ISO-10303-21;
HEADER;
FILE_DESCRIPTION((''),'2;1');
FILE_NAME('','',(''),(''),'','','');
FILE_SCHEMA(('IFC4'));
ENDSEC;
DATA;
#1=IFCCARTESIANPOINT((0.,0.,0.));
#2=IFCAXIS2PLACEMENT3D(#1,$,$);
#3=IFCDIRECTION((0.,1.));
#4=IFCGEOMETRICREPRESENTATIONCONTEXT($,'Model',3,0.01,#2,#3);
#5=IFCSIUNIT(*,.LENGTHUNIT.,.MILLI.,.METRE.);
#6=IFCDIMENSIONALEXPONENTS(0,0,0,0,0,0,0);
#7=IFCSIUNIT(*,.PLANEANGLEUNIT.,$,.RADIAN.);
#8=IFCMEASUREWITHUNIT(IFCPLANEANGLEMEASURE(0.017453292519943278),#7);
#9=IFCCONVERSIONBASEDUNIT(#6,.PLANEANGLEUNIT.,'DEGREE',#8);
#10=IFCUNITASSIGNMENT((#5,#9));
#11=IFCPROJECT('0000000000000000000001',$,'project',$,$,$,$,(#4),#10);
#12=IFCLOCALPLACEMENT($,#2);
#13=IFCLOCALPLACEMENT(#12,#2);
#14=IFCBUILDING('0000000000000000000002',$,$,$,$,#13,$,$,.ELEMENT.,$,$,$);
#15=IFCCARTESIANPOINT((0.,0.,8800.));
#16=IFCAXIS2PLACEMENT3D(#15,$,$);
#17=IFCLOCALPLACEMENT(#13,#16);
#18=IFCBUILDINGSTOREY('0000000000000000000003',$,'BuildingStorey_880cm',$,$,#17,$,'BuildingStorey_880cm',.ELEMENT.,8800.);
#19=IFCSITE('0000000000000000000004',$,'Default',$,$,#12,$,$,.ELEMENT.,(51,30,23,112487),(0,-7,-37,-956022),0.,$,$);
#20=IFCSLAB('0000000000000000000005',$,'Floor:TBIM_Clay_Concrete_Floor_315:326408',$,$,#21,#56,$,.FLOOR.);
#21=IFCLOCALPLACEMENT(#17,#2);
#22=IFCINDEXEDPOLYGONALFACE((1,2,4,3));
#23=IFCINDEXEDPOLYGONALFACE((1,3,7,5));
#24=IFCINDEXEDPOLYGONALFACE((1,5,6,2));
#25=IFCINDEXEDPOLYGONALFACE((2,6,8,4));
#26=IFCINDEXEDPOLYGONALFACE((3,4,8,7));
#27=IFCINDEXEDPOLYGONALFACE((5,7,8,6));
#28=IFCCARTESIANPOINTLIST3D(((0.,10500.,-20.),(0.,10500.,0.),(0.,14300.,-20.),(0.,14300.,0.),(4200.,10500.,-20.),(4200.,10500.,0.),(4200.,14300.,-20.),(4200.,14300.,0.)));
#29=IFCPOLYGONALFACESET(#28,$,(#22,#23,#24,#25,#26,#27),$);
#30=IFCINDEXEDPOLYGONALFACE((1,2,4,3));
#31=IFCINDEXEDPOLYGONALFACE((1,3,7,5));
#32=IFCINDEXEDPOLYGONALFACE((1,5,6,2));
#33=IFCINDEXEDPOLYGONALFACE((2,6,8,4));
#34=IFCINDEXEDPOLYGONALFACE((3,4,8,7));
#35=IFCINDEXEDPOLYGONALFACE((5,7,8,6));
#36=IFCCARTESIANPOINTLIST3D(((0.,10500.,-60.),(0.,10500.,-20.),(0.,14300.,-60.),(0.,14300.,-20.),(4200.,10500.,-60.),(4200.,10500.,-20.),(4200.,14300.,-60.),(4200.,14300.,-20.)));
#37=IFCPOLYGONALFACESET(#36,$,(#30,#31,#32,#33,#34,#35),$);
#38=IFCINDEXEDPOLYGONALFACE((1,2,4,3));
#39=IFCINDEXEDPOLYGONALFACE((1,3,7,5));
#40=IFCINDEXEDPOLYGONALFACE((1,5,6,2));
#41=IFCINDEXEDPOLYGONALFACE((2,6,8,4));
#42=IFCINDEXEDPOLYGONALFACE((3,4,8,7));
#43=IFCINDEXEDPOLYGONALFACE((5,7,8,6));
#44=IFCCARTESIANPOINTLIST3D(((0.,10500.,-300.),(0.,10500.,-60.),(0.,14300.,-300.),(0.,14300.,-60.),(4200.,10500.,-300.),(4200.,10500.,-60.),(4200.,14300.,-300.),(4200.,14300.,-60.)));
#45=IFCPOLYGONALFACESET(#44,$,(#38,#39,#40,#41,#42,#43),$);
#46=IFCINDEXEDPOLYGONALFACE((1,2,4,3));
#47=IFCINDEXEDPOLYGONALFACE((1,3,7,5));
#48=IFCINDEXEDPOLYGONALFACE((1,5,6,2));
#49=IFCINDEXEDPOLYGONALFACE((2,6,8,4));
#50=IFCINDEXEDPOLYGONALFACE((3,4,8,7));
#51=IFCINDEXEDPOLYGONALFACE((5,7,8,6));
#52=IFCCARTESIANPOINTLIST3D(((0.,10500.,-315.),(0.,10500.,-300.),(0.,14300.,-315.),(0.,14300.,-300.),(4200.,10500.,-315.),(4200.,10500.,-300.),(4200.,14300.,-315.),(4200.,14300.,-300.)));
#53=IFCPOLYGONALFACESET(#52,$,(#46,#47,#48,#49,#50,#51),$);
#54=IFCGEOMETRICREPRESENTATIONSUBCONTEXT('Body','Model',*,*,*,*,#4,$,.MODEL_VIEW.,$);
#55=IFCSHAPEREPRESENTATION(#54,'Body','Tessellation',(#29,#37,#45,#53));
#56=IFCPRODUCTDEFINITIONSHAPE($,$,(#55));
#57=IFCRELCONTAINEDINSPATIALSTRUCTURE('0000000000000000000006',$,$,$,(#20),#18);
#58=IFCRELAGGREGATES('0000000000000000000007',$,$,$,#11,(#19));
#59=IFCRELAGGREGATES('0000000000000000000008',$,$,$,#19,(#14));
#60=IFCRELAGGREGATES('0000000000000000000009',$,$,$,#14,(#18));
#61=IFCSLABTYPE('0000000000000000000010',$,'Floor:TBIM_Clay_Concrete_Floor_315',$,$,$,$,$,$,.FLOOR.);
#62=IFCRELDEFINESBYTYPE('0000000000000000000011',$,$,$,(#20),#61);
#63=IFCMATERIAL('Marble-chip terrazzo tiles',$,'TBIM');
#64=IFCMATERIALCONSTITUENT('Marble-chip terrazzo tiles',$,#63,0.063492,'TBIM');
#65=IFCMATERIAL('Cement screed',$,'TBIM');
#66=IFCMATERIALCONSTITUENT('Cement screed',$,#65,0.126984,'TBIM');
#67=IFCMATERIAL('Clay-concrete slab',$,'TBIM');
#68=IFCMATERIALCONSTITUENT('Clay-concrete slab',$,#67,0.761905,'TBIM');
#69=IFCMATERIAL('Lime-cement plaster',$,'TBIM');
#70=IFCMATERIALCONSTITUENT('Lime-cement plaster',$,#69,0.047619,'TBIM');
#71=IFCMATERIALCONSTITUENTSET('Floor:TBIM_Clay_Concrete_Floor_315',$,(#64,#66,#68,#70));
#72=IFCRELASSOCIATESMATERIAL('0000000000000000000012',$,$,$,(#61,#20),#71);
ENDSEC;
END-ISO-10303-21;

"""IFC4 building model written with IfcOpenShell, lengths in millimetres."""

from ifc_helpers import new_model, entity, si_unit, converted_unit, direction, frame, origin, place, context, subcontext, project, spatial, indexed_curve, outline, extrude, material, constituent, constituent_set, type_object, element, save


model = new_model("IFC4")

# Units and contexts
model_context = context("Model", 3, precision=0.01, world=origin(), true_north=direction((0.0, 1.0)))
body_context = subcontext(model_context, "Body", "Model", "MODEL_VIEW")
ifc_project = project(units=[si_unit("LENGTHUNIT", "METRE", prefix="MILLI"), converted_unit("PLANEANGLEUNIT", "DEGREE", entity("IfcPlaneAngleMeasure", 0.017453292519943278), si_unit("PLANEANGLEUNIT", "RADIAN"), dimensions=[0, 0, 0, 0, 0, 0, 0])], contexts=[model_context])

# Site, building, storey
site_placement = place(None, origin())
site = spatial("IfcSite", under=ifc_project, at=site_placement, Name="Default", CompositionType="ELEMENT", RefLatitude=(51, 30, 23, 112487), RefLongitude=(0, -7, -37, -956022), RefElevation=0.0)
building_placement = place(site_placement, origin())
building = spatial("IfcBuilding", under=site, at=building_placement, CompositionType="ELEMENT")
storey_placement = place(building_placement, frame((0.0, 0.0, 8800.0)))
storey = spatial("IfcBuildingStorey", under=building, at=storey_placement, Name="BuildingStorey_880cm", LongName="BuildingStorey_880cm", CompositionType="ELEMENT", Elevation=8800.0)

# Slab
ifc_material_1 = material(Name="Marble-chip terrazzo tiles", Category="TBIM")
ifc_constituent_1 = constituent(ifc_material_1, Name="Marble-chip terrazzo tiles", Category="TBIM", fraction=0.063492)
ifc_material_2 = material(Name="Cement screed", Category="TBIM")
ifc_constituent_2 = constituent(ifc_material_2, Name="Cement screed", Category="TBIM", fraction=0.126984)
ifc_material_3 = material(Name="Clay-concrete slab", Category="TBIM")
ifc_constituent_3 = constituent(ifc_material_3, Name="Clay-concrete slab", Category="TBIM", fraction=0.761905)
ifc_material_4 = material(Name="Lime-cement plaster", Category="TBIM")
ifc_constituent_4 = constituent(ifc_material_4, Name="Lime-cement plaster", Category="TBIM", fraction=0.047619)
ifc_constituent_set_1 = constituent_set(constituents=[ifc_constituent_1, ifc_constituent_2, ifc_constituent_3, ifc_constituent_4], Name="Floor:TBIM_Clay_Concrete_Floor_315")
slab_type = type_object("IfcSlabType", Name="Floor:TBIM_Clay_Concrete_Floor_315", PredefinedType="FLOOR", material=ifc_constituent_set_1)
slab_1_placement = place(storey_placement, origin())
element("IfcSlab", 1, at=slab_1_placement, inside=storey, type_object=slab_type, material=ifc_constituent_set_1, Name="Floor:TBIM_Clay_Concrete_Floor_315:326408", PredefinedType="FLOOR", context=body_context, shape_type="SweptSolid", body=[
    extrude(outline(indexed_curve([(-2100.0, -1900.0), (2100.0, -1900.0), (2100.0, 1900.0), (-2100.0, 1900.0), (-2100.0, -1900.0)], self_intersect=False)), frame((2100.0, 12400.0, -20.0), z_axis=(0.0, 0.0, 1.0), x_axis=(-1.0, 0.0, 0.0)), (0.0, 0.0, 1.0), 20.0),
    extrude(outline(indexed_curve([(-2100.0, -1900.0), (2100.0, -1900.0), (2100.0, 1900.0), (-2100.0, 1900.0), (-2100.0, -1900.0)], self_intersect=False)), frame((2100.0, 12400.0, -60.0), z_axis=(0.0, 0.0, 1.0), x_axis=(-1.0, 0.0, 0.0)), (0.0, 0.0, 1.0), 40.0),
    extrude(outline(indexed_curve([(-2100.0, -1900.0), (2100.0, -1900.0), (2100.0, 1900.0), (-2100.0, 1900.0), (-2100.0, -1900.0)], self_intersect=False)), frame((2100.0, 12400.0, -300.0), z_axis=(0.0, 0.0, 1.0), x_axis=(-1.0, 0.0, 0.0)), (0.0, 0.0, 1.0), 240.0),
    extrude(outline(indexed_curve([(-2100.0, -1900.0), (2100.0, -1900.0), (2100.0, 1900.0), (-2100.0, 1900.0), (-2100.0, -1900.0)], self_intersect=False)), frame((2100.0, 12400.0, -315.0), z_axis=(0.0, 0.0, 1.0), x_axis=(-1.0, 0.0, 0.0)), (0.0, 0.0, 1.0), 15.0),
])

save(model, "model.ifc")
